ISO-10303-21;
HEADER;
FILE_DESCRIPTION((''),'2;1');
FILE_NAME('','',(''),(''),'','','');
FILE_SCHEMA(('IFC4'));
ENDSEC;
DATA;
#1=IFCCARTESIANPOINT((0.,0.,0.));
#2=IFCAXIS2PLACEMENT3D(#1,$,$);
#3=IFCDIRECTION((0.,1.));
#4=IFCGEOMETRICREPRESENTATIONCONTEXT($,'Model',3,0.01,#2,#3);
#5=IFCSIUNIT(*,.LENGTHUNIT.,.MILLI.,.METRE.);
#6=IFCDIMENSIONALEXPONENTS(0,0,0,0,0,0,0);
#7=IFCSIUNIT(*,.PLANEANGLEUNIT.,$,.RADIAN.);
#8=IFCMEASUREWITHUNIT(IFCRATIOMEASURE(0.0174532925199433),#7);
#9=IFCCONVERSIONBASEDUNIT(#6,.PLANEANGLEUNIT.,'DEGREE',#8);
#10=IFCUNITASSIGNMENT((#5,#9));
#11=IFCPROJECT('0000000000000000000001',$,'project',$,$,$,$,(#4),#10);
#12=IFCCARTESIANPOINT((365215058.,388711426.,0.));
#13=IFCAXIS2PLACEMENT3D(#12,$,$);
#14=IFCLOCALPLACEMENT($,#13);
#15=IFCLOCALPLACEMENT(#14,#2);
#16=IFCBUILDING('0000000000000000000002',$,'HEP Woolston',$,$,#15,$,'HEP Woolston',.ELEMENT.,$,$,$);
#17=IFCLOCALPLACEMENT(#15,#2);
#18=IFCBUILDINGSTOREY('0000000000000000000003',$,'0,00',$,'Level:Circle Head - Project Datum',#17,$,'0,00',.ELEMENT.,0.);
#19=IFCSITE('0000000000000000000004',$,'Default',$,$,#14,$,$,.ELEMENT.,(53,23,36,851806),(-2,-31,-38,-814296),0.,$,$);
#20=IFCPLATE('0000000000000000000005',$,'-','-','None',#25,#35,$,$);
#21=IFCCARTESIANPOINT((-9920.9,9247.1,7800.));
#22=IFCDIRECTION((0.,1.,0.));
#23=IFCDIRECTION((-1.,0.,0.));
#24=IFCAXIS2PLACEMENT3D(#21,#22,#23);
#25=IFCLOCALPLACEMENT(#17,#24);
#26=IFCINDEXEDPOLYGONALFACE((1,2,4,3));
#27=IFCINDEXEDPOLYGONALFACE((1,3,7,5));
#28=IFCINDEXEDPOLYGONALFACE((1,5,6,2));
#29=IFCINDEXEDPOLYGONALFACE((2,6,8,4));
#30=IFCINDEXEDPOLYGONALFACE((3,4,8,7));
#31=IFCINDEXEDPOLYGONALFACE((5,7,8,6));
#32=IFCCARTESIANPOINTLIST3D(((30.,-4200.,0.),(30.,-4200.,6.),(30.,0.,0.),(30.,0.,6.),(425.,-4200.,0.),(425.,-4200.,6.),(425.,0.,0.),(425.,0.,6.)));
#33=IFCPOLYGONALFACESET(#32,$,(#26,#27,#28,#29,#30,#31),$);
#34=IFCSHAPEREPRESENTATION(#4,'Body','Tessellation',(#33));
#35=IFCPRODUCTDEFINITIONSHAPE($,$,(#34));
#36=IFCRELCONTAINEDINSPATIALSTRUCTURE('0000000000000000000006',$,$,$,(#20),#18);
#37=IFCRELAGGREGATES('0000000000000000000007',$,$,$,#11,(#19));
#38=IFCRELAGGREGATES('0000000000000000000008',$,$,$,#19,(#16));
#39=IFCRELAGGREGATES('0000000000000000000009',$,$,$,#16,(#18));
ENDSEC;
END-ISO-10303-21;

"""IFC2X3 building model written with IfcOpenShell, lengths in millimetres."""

from ifc_helpers import new_model, entity, si_unit, converted_unit, direction, frame, origin, origin_with_axes, place, context, project, spatial, polyline, outline, extrude, element, save


model = new_model("IFC2X3")

# Units and contexts
model_context = context("Model", 3, precision=0.01, world=origin(), true_north=direction((0.0, 1.0)))
ifc_project = project(units=[si_unit("LENGTHUNIT", "METRE", prefix="MILLI"), converted_unit("PLANEANGLEUNIT", "DEGREE", entity("IfcRatioMeasure", 0.0174532925199433), si_unit("PLANEANGLEUNIT", "RADIAN"), dimensions=[0, 0, 0, 0, 0, 0, 0])], contexts=[model_context])

# Site, building, storey
site_placement = place(None, frame((365215058.0, 388711426.0, 0.0)))
site = spatial("IfcSite", under=ifc_project, at=site_placement, Name="Default", CompositionType="ELEMENT", RefLatitude=(53, 23, 36, 851806), RefLongitude=(-2, -31, -38, -814296), RefElevation=0.0)
building_placement = place(site_placement, origin())
building = spatial("IfcBuilding", under=site, at=building_placement, Name="HEP Woolston", LongName="HEP Woolston", CompositionType="ELEMENT")
storey_placement = place(building_placement, origin())
storey = spatial("IfcBuildingStorey", under=building, at=storey_placement, Name="0,00", ObjectType="Level:Circle Head - Project Datum", LongName="0,00", CompositionType="ELEMENT", Elevation=0.0)

# Plate
plate_1_placement = place(storey_placement, frame((-9920.9, 9247.1, 7800.0), z_axis=(0.0, 1.0, 0.0), x_axis=(-1.0, 0.0, 0.0)))
element("IfcPlate", 1, at=plate_1_placement, inside=storey, Name="-", Description="-", ObjectType="None", context=model_context, shape_type="SweptSolid", body=[
    extrude(outline(polyline([(30.0, 0.0), (30.0, -4200.0), (425.0, -4200.0), (425.0, 0.0), (30.0, 0.0)])), origin_with_axes(), (0.0, 0.0, 1.0), 6.0),
])

save(model, "model.ifc")
